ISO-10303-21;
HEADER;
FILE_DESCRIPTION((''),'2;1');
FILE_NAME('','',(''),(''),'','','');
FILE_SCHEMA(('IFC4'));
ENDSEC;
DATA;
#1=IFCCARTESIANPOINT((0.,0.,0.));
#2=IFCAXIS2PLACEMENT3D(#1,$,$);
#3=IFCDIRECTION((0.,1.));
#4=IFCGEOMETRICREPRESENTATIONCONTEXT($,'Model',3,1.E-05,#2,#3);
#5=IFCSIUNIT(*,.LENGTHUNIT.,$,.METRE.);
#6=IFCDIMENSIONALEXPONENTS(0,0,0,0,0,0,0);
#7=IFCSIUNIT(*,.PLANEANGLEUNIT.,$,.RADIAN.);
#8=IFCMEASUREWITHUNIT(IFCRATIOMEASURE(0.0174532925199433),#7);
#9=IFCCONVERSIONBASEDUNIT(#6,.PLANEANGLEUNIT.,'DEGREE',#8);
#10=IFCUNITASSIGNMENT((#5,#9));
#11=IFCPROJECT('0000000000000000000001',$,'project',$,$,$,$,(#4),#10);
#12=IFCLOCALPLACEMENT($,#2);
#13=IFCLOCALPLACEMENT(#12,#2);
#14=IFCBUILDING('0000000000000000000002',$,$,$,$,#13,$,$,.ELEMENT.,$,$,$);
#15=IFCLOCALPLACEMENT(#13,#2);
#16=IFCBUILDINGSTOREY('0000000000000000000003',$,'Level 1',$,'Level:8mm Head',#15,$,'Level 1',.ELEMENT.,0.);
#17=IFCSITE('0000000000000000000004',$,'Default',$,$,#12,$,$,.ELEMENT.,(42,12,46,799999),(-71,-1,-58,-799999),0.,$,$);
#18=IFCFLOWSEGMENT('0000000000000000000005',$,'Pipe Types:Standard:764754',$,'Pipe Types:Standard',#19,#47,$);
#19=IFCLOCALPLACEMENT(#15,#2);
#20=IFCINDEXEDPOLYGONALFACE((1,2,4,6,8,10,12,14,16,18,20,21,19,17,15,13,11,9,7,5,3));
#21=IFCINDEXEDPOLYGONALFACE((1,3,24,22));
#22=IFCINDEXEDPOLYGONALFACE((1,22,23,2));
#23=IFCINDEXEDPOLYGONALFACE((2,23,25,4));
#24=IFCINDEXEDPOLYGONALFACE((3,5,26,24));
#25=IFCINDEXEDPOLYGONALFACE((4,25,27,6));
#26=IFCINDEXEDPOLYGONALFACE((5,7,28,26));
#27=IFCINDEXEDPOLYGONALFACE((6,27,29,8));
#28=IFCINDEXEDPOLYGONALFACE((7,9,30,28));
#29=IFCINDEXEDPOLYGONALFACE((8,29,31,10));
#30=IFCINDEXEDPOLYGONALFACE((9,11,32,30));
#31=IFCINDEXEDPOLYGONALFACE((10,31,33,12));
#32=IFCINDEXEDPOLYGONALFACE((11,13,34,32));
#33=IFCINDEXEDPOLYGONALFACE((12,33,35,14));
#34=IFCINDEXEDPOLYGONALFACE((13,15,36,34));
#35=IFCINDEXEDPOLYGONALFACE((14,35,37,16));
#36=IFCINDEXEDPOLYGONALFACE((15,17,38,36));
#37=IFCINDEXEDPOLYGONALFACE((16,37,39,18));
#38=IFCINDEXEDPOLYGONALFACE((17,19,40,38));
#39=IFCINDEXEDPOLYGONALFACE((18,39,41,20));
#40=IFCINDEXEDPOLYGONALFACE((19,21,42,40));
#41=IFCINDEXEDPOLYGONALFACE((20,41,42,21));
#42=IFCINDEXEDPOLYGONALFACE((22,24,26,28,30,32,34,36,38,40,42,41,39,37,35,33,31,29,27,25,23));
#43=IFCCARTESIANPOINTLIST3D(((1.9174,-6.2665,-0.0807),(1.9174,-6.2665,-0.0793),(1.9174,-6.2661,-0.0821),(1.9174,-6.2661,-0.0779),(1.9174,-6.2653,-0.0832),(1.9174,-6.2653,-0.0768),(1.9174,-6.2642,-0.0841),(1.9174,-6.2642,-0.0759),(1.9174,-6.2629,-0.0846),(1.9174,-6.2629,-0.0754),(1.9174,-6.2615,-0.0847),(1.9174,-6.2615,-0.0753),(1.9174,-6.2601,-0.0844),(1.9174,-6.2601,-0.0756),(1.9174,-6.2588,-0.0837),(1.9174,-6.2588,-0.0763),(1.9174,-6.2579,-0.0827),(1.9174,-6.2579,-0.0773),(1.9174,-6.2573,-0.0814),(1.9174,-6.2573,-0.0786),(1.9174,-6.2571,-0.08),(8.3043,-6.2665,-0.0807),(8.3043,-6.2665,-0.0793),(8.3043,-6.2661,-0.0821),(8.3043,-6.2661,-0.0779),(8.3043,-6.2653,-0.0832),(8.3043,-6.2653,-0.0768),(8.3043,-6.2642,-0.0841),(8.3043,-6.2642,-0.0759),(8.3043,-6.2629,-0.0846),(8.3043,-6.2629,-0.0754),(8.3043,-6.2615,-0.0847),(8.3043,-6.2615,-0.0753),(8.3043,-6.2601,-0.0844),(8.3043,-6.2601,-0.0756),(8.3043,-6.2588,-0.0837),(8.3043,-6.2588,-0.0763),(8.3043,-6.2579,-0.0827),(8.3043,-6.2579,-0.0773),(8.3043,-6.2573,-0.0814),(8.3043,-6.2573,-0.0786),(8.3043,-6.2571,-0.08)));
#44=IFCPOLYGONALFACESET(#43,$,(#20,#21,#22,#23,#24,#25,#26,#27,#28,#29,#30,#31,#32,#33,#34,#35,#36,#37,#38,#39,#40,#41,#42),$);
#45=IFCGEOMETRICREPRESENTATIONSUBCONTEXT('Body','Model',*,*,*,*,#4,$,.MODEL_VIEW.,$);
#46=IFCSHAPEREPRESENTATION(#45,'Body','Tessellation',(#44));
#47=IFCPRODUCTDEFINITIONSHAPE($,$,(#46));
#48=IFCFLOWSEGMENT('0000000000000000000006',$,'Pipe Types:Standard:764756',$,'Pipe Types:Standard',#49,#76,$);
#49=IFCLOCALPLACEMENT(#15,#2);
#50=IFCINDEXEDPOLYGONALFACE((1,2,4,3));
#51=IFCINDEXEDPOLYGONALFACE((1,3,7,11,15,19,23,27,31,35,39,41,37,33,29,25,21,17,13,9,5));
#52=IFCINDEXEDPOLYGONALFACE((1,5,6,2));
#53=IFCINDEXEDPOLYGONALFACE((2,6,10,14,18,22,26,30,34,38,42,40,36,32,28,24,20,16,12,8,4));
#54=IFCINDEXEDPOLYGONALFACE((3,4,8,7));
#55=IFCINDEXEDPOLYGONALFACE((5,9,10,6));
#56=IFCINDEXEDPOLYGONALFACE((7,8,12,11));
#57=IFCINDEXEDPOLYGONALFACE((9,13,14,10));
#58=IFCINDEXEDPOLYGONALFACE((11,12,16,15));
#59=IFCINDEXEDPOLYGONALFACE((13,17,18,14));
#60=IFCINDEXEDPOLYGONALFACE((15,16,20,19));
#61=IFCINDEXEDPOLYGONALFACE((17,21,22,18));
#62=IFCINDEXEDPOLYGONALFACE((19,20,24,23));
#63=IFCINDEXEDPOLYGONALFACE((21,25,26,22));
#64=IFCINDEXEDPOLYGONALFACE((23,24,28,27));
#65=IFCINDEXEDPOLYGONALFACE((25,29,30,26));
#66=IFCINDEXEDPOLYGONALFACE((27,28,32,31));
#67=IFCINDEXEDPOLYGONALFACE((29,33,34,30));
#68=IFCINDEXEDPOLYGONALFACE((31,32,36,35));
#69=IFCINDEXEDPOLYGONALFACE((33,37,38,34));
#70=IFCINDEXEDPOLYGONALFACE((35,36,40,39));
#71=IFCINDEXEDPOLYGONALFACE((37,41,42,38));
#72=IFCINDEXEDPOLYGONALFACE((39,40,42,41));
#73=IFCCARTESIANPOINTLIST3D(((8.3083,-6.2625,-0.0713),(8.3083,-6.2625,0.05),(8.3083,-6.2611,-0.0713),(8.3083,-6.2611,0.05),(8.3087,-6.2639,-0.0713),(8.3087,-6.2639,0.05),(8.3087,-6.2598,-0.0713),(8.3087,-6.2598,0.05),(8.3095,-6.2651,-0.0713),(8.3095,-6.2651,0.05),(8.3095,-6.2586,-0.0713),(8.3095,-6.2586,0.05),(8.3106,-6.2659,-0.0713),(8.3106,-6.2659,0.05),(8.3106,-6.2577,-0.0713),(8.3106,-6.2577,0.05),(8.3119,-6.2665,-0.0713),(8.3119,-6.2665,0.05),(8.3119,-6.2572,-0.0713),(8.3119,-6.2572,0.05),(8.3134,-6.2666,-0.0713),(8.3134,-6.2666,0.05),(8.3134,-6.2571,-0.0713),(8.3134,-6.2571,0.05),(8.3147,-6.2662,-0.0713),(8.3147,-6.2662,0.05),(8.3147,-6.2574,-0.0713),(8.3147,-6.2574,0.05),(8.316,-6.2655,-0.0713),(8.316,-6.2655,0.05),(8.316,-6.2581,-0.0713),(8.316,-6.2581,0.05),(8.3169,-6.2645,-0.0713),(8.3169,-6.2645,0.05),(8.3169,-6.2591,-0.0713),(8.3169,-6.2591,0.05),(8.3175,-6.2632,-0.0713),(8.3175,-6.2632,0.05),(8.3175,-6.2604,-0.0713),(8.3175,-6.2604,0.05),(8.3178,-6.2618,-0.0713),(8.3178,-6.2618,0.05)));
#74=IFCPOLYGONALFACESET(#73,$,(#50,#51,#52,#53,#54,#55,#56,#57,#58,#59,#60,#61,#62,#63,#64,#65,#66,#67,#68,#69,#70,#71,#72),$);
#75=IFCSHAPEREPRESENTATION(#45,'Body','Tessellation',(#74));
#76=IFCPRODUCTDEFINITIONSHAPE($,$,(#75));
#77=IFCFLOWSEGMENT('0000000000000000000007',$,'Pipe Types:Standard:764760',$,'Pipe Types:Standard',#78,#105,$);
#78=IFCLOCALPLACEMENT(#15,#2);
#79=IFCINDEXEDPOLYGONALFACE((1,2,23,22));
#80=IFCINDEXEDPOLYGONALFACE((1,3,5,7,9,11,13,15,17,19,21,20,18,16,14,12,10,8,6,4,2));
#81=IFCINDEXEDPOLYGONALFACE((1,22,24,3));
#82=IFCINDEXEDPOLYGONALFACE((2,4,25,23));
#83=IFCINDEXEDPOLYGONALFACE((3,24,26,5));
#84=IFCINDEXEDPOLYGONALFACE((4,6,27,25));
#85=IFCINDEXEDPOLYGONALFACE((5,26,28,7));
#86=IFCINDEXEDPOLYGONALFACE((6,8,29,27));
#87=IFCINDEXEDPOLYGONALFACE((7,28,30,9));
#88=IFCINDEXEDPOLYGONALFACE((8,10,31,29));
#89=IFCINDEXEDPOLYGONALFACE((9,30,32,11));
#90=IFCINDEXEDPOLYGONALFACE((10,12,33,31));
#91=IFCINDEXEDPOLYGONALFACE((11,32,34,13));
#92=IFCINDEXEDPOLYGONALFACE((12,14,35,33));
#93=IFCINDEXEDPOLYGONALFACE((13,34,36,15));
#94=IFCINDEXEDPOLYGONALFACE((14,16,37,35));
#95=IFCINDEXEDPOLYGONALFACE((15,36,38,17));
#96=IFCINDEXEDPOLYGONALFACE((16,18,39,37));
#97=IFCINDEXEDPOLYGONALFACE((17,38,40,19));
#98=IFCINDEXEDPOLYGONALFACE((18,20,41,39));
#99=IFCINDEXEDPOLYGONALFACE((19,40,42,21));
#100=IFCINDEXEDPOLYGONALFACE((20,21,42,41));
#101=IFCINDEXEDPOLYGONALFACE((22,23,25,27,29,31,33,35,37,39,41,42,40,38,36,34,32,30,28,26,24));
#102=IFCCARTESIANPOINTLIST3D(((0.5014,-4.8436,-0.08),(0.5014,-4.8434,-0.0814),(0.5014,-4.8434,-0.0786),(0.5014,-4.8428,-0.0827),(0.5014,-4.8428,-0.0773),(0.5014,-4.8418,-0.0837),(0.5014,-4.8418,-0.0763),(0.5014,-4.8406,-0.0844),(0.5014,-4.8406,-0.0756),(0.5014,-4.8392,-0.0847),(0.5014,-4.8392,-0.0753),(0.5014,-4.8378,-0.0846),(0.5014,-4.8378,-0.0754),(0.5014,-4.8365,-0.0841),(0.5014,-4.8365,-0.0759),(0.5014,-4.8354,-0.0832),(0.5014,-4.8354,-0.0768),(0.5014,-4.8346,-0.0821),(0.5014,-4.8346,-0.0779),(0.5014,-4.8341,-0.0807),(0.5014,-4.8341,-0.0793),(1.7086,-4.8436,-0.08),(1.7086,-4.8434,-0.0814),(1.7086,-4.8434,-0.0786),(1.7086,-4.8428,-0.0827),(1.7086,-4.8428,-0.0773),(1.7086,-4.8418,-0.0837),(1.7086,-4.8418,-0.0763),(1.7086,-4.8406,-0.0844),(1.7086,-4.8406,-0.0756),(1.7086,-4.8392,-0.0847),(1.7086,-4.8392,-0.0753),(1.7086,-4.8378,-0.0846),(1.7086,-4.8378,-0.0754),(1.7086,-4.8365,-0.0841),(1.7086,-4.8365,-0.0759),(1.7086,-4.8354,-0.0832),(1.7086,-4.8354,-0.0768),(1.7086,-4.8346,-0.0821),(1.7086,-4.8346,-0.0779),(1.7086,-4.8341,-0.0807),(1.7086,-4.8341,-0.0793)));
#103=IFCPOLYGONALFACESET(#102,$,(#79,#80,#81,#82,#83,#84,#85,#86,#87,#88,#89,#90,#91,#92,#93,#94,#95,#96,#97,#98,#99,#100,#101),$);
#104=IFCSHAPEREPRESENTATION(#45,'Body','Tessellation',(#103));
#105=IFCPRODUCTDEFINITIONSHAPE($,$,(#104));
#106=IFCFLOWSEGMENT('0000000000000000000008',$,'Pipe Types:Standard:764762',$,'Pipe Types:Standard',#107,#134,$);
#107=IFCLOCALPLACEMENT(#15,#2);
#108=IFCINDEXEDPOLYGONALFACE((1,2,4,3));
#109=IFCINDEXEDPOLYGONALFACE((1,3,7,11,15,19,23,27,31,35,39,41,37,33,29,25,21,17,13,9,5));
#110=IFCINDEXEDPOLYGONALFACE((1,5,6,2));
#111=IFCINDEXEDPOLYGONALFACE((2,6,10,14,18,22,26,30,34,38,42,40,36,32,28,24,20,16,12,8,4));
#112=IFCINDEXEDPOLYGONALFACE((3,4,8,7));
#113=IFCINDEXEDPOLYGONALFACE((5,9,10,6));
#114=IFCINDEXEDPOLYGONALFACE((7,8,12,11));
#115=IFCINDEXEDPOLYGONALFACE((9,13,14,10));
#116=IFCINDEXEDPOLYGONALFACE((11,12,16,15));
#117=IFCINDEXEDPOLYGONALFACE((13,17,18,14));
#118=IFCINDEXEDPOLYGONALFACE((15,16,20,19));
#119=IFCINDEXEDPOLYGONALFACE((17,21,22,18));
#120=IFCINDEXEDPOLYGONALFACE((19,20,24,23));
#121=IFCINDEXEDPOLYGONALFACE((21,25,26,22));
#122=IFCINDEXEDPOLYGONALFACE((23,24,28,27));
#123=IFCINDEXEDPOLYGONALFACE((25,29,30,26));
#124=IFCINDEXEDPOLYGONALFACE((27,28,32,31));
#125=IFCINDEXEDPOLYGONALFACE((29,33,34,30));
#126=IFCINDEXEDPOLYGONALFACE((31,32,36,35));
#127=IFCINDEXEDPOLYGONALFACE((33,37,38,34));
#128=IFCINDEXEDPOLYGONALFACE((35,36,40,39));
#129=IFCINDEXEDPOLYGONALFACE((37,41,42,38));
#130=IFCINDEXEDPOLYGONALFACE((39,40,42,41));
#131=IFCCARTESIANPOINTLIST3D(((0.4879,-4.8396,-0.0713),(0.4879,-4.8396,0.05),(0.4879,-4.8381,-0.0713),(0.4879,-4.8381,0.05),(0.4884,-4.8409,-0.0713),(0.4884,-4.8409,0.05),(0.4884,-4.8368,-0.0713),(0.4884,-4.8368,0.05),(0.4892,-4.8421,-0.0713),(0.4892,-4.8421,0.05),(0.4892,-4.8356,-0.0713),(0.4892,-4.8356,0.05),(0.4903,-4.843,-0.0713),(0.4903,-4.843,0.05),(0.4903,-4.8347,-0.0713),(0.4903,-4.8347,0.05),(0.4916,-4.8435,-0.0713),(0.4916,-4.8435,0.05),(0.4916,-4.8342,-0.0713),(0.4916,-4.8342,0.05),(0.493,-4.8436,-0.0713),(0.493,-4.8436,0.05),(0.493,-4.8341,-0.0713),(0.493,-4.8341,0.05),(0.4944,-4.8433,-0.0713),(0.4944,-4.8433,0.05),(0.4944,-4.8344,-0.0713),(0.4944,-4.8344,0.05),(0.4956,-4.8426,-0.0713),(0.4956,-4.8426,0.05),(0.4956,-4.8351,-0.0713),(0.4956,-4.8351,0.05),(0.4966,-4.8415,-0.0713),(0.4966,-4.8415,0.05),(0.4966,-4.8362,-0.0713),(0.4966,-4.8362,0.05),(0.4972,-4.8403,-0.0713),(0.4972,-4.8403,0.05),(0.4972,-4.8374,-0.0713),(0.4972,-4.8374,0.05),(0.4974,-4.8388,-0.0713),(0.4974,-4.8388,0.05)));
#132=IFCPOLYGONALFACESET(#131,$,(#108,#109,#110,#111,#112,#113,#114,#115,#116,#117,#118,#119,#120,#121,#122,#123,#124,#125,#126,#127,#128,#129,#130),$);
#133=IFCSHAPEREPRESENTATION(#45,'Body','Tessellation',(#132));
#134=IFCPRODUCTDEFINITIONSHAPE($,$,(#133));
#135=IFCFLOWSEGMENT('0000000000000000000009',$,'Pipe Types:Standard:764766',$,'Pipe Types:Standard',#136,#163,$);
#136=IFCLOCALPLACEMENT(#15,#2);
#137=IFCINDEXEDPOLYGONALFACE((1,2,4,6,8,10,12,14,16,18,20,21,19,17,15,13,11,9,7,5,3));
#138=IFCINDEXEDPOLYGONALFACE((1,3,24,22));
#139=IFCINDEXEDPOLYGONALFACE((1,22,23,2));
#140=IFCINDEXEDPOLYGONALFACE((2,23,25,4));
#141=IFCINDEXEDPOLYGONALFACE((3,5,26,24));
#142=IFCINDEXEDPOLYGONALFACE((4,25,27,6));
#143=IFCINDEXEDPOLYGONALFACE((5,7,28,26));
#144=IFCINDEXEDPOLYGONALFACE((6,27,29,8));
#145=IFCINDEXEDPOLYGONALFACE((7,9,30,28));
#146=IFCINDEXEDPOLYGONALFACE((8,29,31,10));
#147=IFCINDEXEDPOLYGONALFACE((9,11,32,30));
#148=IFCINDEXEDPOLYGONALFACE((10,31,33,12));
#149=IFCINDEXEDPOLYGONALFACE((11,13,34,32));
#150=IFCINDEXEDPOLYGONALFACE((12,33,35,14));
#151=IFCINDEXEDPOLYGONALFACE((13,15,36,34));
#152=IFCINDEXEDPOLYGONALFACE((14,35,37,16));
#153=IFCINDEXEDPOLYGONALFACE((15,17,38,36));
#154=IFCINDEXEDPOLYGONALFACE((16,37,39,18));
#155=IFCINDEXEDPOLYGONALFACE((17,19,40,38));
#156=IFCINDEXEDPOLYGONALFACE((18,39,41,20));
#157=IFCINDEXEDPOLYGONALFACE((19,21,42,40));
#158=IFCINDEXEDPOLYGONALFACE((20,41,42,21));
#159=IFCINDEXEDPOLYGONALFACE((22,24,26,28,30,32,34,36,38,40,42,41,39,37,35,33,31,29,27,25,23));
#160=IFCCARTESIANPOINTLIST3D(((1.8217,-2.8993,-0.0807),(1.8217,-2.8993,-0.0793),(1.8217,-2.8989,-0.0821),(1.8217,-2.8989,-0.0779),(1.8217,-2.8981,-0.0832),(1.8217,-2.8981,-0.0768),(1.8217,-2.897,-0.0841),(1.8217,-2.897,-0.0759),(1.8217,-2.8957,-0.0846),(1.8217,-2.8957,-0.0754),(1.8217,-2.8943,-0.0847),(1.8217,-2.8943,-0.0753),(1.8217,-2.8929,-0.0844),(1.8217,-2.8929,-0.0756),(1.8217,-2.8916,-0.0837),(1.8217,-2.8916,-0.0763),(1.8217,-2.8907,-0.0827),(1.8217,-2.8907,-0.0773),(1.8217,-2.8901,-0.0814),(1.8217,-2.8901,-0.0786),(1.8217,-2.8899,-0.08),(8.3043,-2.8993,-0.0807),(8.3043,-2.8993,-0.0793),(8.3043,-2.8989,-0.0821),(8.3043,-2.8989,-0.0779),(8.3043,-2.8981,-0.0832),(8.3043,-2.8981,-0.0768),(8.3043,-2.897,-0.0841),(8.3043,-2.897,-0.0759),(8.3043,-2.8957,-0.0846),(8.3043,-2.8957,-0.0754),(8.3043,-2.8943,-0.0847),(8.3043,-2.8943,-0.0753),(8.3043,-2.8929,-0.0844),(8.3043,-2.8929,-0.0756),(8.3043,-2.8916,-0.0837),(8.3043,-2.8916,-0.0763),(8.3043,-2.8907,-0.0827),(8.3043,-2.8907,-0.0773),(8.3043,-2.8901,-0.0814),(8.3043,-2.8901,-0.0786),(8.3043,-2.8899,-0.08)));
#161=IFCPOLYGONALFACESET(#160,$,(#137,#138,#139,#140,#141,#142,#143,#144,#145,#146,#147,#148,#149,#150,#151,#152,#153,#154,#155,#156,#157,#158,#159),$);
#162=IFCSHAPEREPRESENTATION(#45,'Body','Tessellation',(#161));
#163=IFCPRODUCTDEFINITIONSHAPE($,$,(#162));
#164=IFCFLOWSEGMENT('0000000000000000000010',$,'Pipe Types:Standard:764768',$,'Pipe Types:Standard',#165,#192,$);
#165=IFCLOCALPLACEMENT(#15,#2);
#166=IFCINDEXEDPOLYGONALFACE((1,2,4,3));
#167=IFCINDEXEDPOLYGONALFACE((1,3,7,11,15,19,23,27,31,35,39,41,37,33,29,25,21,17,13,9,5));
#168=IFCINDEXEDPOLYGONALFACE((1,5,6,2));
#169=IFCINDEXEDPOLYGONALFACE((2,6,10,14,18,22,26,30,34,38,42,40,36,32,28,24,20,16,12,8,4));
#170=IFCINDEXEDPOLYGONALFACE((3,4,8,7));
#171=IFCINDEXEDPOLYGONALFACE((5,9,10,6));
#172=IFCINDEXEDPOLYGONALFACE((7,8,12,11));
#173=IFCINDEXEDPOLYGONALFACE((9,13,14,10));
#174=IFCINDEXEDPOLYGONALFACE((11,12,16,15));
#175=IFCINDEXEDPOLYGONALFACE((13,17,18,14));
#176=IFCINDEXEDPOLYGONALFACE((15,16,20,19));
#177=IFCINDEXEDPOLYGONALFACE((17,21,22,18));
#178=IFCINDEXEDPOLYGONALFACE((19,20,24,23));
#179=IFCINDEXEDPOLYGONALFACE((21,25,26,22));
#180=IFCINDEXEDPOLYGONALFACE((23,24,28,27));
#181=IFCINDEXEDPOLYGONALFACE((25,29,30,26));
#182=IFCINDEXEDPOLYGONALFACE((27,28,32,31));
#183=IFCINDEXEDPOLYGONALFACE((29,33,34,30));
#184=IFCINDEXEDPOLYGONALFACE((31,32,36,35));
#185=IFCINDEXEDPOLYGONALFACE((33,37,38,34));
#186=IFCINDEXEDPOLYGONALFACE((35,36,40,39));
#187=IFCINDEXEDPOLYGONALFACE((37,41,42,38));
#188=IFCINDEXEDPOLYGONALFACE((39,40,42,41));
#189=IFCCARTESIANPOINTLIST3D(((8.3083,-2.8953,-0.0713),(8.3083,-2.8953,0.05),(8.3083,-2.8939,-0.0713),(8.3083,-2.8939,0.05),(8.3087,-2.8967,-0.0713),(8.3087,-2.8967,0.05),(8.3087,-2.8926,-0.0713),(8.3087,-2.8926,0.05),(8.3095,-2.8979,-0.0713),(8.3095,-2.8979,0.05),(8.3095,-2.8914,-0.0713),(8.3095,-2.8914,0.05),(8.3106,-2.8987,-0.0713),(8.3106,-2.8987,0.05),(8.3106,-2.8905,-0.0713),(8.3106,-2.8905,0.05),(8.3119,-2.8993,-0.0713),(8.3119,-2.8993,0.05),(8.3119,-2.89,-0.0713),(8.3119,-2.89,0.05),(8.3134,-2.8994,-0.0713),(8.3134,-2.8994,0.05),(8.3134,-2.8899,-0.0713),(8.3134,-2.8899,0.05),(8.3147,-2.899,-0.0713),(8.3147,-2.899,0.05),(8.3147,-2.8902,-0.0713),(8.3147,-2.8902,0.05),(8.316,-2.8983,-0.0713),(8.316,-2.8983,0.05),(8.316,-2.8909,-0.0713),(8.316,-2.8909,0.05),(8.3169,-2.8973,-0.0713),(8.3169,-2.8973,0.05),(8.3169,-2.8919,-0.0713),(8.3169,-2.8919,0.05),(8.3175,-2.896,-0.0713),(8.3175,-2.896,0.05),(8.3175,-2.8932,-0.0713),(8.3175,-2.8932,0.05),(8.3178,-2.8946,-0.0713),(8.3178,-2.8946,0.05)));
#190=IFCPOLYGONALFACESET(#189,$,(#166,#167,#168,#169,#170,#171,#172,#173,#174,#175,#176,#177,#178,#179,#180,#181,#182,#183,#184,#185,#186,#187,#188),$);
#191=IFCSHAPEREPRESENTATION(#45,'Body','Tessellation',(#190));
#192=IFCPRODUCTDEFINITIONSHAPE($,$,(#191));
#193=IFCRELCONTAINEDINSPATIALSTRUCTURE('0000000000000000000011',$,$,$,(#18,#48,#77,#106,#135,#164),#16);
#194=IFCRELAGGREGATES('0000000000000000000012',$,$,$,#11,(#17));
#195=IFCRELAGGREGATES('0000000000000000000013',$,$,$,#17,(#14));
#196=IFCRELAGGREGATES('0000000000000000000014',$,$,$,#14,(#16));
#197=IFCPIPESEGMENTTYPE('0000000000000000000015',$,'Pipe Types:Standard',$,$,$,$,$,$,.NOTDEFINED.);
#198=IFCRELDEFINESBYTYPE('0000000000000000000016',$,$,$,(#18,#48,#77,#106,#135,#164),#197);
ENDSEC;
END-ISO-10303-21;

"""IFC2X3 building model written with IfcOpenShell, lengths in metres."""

from ifc_helpers import new_model, entity, si_unit, converted_unit, direction, frame, frame_2d, origin, origin_2d_with_axis, place, context, subcontext, project, spatial, circle, extrude, type_object, element, save


model = new_model("IFC2X3")

# Units and contexts
model_context = context("Model", 3, precision=1e-05, world=origin(), true_north=direction((0.0, 1.0)))
body_context = subcontext(model_context, "Body", "Model", "MODEL_VIEW")
ifc_project = project(units=[si_unit("LENGTHUNIT", "METRE"), converted_unit("PLANEANGLEUNIT", "DEGREE", entity("IfcRatioMeasure", 0.0174532925199433), si_unit("PLANEANGLEUNIT", "RADIAN"), dimensions=[0, 0, 0, 0, 0, 0, 0])], contexts=[model_context])

# Site, building, storey
site_placement = place(None, origin())
site = spatial("IfcSite", under=ifc_project, at=site_placement, Name="Default", CompositionType="ELEMENT", RefLatitude=(42, 12, 46, 799999), RefLongitude=(-71, -1, -58, -799999), RefElevation=0.0)
building_placement = place(site_placement, origin())
building = spatial("IfcBuilding", under=site, at=building_placement, CompositionType="ELEMENT")
storey_placement = place(building_placement, origin())
storey = spatial("IfcBuildingStorey", under=building, at=storey_placement, Name="Level 1", ObjectType="Level:8mm Head", LongName="Level 1", CompositionType="ELEMENT", Elevation=0.0)

# Flow segments
pipe_segment_type = type_object("IfcPipeSegmentType", Name="Pipe Types:Standard", PredefinedType="NOTDEFINED")
flow_segment_1_placement = place(storey_placement, origin())
element("IfcFlowSegment", 1, at=flow_segment_1_placement, inside=storey, type_object=pipe_segment_type, Name="Pipe Types:Standard:764754", ObjectType="Pipe Types:Standard", context=body_context, shape_type="SweptSolid", body=[
    extrude(circle(Radius=0.0048, at=frame_2d((0.0, 0.0), x_axis=(1.0, 0.0))), frame((1.9174, -6.2618, -0.08), z_axis=(1.0, 0.0, 0.0), x_axis=(0.0, 1.0, 0.0)), (0.0, 0.0, 1.0), 6.3868),
])
flow_segment_2_placement = place(storey_placement, origin())
element("IfcFlowSegment", 2, at=flow_segment_2_placement, inside=storey, type_object=pipe_segment_type, Name="Pipe Types:Standard:764756", ObjectType="Pipe Types:Standard", context=body_context, shape_type="SweptSolid", body=[
    extrude(circle(Radius=0.0048, at=origin_2d_with_axis()), frame((8.313, -6.2618, -0.0713)), (0.0, 0.0, 1.0), 0.1213),
])
flow_segment_3_placement = place(storey_placement, origin())
element("IfcFlowSegment", 3, at=flow_segment_3_placement, inside=storey, type_object=pipe_segment_type, Name="Pipe Types:Standard:764760", ObjectType="Pipe Types:Standard", context=body_context, shape_type="SweptSolid", body=[
    extrude(circle(Radius=0.0048, at=origin_2d_with_axis()), frame((0.5014, -4.8388, -0.08), z_axis=(1.0, 0.0, 0.0), x_axis=(0.0, -1.0, 0.0)), (0.0, 0.0, 1.0), 1.2072),
])
flow_segment_4_placement = place(storey_placement, origin())
element("IfcFlowSegment", 4, at=flow_segment_4_placement, inside=storey, type_object=pipe_segment_type, Name="Pipe Types:Standard:764762", ObjectType="Pipe Types:Standard", context=body_context, shape_type="SweptSolid", body=[
    extrude(circle(Radius=0.0048, at=origin_2d_with_axis()), frame((0.4926, -4.8388, -0.0713)), (0.0, 0.0, 1.0), 0.1213),
])
flow_segment_5_placement = place(storey_placement, origin())
element("IfcFlowSegment", 5, at=flow_segment_5_placement, inside=storey, type_object=pipe_segment_type, Name="Pipe Types:Standard:764766", ObjectType="Pipe Types:Standard", context=body_context, shape_type="SweptSolid", body=[
    extrude(circle(Radius=0.0048, at=frame_2d((0.0, 0.0), x_axis=(1.0, 0.0))), frame((1.8217, -2.8946, -0.08), z_axis=(1.0, 0.0, 0.0), x_axis=(0.0, 1.0, 0.0)), (0.0, 0.0, 1.0), 6.4826),
])
flow_segment_6_placement = place(storey_placement, origin())
element("IfcFlowSegment", 6, at=flow_segment_6_placement, inside=storey, type_object=pipe_segment_type, Name="Pipe Types:Standard:764768", ObjectType="Pipe Types:Standard", context=body_context, shape_type="SweptSolid", body=[
    extrude(circle(Radius=0.0048, at=origin_2d_with_axis()), frame((8.313, -2.8946, -0.0713)), (0.0, 0.0, 1.0), 0.1213),
])

save(model, "model.ifc")
